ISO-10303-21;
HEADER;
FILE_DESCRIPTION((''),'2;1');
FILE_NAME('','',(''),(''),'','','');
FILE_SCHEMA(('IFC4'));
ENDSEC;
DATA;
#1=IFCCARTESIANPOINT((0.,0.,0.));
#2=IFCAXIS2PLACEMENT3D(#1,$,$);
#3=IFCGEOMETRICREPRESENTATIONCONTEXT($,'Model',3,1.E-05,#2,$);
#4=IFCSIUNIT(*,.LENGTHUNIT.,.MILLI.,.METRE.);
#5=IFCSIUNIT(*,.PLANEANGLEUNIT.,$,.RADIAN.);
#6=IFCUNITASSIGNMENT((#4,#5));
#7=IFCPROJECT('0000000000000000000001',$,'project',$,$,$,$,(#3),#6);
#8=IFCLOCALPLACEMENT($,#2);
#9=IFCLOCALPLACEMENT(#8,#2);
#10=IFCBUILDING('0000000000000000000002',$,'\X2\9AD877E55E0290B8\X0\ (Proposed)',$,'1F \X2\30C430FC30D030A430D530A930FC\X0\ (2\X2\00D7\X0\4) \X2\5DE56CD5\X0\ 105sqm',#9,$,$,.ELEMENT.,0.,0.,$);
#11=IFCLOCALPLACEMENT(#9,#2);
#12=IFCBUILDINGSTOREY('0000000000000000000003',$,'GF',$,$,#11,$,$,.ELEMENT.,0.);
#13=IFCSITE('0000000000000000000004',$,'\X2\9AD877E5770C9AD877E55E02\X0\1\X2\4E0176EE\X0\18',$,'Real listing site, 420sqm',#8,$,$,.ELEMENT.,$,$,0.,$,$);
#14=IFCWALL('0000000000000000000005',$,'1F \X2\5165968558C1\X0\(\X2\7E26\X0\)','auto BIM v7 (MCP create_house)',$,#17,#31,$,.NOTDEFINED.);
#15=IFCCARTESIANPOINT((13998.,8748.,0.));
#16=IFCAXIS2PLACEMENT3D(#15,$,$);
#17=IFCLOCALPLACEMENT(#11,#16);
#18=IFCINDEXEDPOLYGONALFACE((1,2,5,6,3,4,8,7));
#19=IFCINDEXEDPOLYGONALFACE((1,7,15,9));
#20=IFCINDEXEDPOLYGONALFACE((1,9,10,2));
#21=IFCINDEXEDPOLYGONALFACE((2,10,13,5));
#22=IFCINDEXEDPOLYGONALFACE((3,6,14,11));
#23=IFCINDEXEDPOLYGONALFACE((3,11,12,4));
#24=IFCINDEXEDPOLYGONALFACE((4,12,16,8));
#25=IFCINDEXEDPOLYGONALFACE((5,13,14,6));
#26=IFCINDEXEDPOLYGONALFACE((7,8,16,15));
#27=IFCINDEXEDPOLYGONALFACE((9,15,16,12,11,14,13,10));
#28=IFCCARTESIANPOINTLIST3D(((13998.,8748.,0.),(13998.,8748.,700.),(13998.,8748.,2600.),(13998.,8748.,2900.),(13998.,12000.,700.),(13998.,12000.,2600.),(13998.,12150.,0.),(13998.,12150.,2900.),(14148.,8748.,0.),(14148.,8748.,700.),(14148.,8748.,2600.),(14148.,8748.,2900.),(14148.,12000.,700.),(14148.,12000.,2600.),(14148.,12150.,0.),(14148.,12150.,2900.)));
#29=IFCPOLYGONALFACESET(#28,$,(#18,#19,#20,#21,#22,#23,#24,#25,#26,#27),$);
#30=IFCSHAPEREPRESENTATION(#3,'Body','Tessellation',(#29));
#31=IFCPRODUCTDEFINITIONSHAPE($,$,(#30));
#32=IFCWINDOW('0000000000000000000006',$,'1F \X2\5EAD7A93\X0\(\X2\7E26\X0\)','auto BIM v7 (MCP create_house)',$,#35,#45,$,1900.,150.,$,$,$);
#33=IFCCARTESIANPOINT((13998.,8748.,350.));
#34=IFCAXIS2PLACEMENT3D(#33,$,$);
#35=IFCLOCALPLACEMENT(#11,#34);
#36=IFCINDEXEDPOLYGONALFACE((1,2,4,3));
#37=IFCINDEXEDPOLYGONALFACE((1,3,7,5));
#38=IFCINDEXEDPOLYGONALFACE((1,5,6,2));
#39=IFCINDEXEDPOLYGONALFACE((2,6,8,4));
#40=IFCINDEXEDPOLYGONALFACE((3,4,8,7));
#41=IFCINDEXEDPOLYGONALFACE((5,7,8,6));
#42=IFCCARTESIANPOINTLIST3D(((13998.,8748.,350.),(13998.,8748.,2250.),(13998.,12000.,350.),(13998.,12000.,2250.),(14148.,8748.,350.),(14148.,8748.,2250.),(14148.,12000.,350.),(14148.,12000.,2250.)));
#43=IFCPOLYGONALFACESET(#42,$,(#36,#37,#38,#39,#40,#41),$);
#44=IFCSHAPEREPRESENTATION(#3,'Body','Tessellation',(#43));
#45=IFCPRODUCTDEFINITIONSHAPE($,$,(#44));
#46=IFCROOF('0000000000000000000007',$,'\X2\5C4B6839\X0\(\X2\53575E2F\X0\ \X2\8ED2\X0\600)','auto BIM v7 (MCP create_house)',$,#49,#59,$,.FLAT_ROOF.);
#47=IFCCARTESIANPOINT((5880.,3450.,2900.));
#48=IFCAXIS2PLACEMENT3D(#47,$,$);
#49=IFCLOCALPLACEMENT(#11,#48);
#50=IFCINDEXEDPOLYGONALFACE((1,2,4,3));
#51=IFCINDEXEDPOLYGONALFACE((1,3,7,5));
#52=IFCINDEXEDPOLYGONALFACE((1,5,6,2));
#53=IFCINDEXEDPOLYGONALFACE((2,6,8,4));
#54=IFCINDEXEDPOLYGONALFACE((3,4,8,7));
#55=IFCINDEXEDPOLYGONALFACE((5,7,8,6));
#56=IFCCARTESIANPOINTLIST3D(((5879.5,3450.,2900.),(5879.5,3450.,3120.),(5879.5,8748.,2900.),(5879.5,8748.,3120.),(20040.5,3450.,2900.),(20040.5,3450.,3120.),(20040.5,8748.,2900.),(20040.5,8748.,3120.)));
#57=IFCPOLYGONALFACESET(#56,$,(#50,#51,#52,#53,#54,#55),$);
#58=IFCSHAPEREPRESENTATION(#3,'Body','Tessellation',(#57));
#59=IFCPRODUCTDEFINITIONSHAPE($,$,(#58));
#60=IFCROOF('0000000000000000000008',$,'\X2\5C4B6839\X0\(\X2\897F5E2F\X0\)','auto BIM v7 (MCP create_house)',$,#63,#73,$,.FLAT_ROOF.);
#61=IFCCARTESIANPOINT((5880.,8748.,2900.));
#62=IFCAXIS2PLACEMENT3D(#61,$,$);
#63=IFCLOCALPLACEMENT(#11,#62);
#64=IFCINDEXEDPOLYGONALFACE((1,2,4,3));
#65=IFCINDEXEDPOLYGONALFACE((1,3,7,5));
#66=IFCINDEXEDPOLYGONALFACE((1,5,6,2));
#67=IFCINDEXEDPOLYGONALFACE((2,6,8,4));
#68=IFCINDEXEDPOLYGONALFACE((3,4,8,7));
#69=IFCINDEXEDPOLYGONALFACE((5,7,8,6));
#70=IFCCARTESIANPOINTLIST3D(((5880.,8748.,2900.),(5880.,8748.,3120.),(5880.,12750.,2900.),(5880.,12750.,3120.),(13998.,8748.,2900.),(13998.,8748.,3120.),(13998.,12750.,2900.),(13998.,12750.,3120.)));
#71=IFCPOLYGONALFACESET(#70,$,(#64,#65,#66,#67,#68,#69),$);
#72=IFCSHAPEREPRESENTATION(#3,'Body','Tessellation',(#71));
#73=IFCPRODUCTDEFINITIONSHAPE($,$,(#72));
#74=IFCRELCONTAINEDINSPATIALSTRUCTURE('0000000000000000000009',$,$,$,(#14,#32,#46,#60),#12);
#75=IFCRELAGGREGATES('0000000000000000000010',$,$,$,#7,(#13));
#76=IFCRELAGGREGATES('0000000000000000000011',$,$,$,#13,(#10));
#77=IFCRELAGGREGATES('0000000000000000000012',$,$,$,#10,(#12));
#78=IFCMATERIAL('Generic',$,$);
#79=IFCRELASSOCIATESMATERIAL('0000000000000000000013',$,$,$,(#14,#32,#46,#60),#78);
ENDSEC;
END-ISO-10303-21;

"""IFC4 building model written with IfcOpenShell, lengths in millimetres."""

from ifc_helpers import new_model, si_unit, frame, frame_2d, origin, place, context, project, spatial, rectangle, extrude, material, element, fill, save


model = new_model("IFC4")

# Units and contexts
model_context = context("Model", 3, precision=1e-05, world=origin())
ifc_project = project(units=[si_unit("LENGTHUNIT", "METRE", prefix="MILLI"), si_unit("PLANEANGLEUNIT", "RADIAN")], contexts=[model_context])

# Site, building, storey
site_placement = place(None, origin())
site = spatial("IfcSite", under=ifc_project, at=site_placement, Name="高知県高知市1丁目18", ObjectType="Real listing site, 420sqm", CompositionType="ELEMENT", RefElevation=0.0)
building_placement = place(site_placement, origin())
building = spatial("IfcBuilding", under=site, at=building_placement, Name="高知市邸 (Proposed)", ObjectType="1F ツーバイフォー (2×4) 工法 105sqm", CompositionType="ELEMENT", ElevationOfRefHeight=0.0, ElevationOfTerrain=0.0)
storey_placement = place(building_placement, origin())
storey = spatial("IfcBuildingStorey", under=building, at=storey_placement, Name="GF", CompositionType="ELEMENT", Elevation=0.0)

# Shared definitions
ifc_material = material(Name="Generic")

# Wall, opening, window
wall_1_placement = place(storey_placement, frame((13998.0, 8748.0, 0.0)))
wall_1 = element("IfcWall", 1, at=wall_1_placement, inside=storey, material=ifc_material, Name="1F 入隅壁(縦)", Description="auto BIM v7 (MCP create_house)", PredefinedType="NOTDEFINED", context=model_context, shape_type="SweptSolid", body=[
    extrude(rectangle(XDim=150.0, YDim=3402.0, at=frame_2d((75.0, 1701.0))), frame((13998.0, 8748.0, 0.0)), (0.0, 0.0, 1.0), 2900.0),
])
opening_1_placement = place(storey_placement, frame((13998.0, 8748.0, 350.0)))
opening_1 = element("IfcOpeningElement", 2, at=opening_1_placement, cuts=wall_1, PredefinedType="NOTDEFINED", context=model_context, shape_type="SweptSolid", body=[
    extrude(rectangle(XDim=150.0, YDim=3252.0, at=frame_2d((75.0, 1626.0))), frame((13998.0, 8748.0, 350.0)), (0.0, 0.0, 1.0), 1900.0),
])
window_1_placement = place(storey_placement, frame((13998.0, 8748.0, 350.0)))
window_1 = element("IfcWindow", 3, at=window_1_placement, inside=storey, material=ifc_material, Name="1F 庭窓(縦)", Description="auto BIM v7 (MCP create_house)", OverallHeight=1900.0, OverallWidth=150.0, context=model_context, shape_type="SweptSolid", body=[
    extrude(rectangle(XDim=150.0, YDim=3252.0, at=frame_2d((75.0, 1626.0))), frame((13998.0, 8748.0, 350.0)), (0.0, 0.0, 1.0), 1900.0),
])
fill(opening_1, window_1)

# Roofs
roof_1_placement = place(storey_placement, frame((5880.0, 3450.0, 2900.0)))
element("IfcRoof", 4, at=roof_1_placement, inside=storey, material=ifc_material, Name="屋根(南帯 軒600)", Description="auto BIM v7 (MCP create_house)", PredefinedType="FLAT_ROOF", context=model_context, shape_type="SweptSolid", body=[
    extrude(rectangle(XDim=14161.0, YDim=5298.0, at=frame_2d((7080.0, 2649.0))), frame((5880.0, 3450.0, 2900.0)), (0.0, 0.0, 1.0), 220.0),
])
roof_2_placement = place(storey_placement, frame((5880.0, 8748.0, 2900.0)))
element("IfcRoof", 5, at=roof_2_placement, inside=storey, material=ifc_material, Name="屋根(西帯)", Description="auto BIM v7 (MCP create_house)", PredefinedType="FLAT_ROOF", context=model_context, shape_type="SweptSolid", body=[
    extrude(rectangle(XDim=8118.0, YDim=4002.0, at=frame_2d((4059.0, 2001.0))), frame((5880.0, 8748.0, 2900.0)), (0.0, 0.0, 1.0), 220.0),
])

save(model, "model.ifc")
